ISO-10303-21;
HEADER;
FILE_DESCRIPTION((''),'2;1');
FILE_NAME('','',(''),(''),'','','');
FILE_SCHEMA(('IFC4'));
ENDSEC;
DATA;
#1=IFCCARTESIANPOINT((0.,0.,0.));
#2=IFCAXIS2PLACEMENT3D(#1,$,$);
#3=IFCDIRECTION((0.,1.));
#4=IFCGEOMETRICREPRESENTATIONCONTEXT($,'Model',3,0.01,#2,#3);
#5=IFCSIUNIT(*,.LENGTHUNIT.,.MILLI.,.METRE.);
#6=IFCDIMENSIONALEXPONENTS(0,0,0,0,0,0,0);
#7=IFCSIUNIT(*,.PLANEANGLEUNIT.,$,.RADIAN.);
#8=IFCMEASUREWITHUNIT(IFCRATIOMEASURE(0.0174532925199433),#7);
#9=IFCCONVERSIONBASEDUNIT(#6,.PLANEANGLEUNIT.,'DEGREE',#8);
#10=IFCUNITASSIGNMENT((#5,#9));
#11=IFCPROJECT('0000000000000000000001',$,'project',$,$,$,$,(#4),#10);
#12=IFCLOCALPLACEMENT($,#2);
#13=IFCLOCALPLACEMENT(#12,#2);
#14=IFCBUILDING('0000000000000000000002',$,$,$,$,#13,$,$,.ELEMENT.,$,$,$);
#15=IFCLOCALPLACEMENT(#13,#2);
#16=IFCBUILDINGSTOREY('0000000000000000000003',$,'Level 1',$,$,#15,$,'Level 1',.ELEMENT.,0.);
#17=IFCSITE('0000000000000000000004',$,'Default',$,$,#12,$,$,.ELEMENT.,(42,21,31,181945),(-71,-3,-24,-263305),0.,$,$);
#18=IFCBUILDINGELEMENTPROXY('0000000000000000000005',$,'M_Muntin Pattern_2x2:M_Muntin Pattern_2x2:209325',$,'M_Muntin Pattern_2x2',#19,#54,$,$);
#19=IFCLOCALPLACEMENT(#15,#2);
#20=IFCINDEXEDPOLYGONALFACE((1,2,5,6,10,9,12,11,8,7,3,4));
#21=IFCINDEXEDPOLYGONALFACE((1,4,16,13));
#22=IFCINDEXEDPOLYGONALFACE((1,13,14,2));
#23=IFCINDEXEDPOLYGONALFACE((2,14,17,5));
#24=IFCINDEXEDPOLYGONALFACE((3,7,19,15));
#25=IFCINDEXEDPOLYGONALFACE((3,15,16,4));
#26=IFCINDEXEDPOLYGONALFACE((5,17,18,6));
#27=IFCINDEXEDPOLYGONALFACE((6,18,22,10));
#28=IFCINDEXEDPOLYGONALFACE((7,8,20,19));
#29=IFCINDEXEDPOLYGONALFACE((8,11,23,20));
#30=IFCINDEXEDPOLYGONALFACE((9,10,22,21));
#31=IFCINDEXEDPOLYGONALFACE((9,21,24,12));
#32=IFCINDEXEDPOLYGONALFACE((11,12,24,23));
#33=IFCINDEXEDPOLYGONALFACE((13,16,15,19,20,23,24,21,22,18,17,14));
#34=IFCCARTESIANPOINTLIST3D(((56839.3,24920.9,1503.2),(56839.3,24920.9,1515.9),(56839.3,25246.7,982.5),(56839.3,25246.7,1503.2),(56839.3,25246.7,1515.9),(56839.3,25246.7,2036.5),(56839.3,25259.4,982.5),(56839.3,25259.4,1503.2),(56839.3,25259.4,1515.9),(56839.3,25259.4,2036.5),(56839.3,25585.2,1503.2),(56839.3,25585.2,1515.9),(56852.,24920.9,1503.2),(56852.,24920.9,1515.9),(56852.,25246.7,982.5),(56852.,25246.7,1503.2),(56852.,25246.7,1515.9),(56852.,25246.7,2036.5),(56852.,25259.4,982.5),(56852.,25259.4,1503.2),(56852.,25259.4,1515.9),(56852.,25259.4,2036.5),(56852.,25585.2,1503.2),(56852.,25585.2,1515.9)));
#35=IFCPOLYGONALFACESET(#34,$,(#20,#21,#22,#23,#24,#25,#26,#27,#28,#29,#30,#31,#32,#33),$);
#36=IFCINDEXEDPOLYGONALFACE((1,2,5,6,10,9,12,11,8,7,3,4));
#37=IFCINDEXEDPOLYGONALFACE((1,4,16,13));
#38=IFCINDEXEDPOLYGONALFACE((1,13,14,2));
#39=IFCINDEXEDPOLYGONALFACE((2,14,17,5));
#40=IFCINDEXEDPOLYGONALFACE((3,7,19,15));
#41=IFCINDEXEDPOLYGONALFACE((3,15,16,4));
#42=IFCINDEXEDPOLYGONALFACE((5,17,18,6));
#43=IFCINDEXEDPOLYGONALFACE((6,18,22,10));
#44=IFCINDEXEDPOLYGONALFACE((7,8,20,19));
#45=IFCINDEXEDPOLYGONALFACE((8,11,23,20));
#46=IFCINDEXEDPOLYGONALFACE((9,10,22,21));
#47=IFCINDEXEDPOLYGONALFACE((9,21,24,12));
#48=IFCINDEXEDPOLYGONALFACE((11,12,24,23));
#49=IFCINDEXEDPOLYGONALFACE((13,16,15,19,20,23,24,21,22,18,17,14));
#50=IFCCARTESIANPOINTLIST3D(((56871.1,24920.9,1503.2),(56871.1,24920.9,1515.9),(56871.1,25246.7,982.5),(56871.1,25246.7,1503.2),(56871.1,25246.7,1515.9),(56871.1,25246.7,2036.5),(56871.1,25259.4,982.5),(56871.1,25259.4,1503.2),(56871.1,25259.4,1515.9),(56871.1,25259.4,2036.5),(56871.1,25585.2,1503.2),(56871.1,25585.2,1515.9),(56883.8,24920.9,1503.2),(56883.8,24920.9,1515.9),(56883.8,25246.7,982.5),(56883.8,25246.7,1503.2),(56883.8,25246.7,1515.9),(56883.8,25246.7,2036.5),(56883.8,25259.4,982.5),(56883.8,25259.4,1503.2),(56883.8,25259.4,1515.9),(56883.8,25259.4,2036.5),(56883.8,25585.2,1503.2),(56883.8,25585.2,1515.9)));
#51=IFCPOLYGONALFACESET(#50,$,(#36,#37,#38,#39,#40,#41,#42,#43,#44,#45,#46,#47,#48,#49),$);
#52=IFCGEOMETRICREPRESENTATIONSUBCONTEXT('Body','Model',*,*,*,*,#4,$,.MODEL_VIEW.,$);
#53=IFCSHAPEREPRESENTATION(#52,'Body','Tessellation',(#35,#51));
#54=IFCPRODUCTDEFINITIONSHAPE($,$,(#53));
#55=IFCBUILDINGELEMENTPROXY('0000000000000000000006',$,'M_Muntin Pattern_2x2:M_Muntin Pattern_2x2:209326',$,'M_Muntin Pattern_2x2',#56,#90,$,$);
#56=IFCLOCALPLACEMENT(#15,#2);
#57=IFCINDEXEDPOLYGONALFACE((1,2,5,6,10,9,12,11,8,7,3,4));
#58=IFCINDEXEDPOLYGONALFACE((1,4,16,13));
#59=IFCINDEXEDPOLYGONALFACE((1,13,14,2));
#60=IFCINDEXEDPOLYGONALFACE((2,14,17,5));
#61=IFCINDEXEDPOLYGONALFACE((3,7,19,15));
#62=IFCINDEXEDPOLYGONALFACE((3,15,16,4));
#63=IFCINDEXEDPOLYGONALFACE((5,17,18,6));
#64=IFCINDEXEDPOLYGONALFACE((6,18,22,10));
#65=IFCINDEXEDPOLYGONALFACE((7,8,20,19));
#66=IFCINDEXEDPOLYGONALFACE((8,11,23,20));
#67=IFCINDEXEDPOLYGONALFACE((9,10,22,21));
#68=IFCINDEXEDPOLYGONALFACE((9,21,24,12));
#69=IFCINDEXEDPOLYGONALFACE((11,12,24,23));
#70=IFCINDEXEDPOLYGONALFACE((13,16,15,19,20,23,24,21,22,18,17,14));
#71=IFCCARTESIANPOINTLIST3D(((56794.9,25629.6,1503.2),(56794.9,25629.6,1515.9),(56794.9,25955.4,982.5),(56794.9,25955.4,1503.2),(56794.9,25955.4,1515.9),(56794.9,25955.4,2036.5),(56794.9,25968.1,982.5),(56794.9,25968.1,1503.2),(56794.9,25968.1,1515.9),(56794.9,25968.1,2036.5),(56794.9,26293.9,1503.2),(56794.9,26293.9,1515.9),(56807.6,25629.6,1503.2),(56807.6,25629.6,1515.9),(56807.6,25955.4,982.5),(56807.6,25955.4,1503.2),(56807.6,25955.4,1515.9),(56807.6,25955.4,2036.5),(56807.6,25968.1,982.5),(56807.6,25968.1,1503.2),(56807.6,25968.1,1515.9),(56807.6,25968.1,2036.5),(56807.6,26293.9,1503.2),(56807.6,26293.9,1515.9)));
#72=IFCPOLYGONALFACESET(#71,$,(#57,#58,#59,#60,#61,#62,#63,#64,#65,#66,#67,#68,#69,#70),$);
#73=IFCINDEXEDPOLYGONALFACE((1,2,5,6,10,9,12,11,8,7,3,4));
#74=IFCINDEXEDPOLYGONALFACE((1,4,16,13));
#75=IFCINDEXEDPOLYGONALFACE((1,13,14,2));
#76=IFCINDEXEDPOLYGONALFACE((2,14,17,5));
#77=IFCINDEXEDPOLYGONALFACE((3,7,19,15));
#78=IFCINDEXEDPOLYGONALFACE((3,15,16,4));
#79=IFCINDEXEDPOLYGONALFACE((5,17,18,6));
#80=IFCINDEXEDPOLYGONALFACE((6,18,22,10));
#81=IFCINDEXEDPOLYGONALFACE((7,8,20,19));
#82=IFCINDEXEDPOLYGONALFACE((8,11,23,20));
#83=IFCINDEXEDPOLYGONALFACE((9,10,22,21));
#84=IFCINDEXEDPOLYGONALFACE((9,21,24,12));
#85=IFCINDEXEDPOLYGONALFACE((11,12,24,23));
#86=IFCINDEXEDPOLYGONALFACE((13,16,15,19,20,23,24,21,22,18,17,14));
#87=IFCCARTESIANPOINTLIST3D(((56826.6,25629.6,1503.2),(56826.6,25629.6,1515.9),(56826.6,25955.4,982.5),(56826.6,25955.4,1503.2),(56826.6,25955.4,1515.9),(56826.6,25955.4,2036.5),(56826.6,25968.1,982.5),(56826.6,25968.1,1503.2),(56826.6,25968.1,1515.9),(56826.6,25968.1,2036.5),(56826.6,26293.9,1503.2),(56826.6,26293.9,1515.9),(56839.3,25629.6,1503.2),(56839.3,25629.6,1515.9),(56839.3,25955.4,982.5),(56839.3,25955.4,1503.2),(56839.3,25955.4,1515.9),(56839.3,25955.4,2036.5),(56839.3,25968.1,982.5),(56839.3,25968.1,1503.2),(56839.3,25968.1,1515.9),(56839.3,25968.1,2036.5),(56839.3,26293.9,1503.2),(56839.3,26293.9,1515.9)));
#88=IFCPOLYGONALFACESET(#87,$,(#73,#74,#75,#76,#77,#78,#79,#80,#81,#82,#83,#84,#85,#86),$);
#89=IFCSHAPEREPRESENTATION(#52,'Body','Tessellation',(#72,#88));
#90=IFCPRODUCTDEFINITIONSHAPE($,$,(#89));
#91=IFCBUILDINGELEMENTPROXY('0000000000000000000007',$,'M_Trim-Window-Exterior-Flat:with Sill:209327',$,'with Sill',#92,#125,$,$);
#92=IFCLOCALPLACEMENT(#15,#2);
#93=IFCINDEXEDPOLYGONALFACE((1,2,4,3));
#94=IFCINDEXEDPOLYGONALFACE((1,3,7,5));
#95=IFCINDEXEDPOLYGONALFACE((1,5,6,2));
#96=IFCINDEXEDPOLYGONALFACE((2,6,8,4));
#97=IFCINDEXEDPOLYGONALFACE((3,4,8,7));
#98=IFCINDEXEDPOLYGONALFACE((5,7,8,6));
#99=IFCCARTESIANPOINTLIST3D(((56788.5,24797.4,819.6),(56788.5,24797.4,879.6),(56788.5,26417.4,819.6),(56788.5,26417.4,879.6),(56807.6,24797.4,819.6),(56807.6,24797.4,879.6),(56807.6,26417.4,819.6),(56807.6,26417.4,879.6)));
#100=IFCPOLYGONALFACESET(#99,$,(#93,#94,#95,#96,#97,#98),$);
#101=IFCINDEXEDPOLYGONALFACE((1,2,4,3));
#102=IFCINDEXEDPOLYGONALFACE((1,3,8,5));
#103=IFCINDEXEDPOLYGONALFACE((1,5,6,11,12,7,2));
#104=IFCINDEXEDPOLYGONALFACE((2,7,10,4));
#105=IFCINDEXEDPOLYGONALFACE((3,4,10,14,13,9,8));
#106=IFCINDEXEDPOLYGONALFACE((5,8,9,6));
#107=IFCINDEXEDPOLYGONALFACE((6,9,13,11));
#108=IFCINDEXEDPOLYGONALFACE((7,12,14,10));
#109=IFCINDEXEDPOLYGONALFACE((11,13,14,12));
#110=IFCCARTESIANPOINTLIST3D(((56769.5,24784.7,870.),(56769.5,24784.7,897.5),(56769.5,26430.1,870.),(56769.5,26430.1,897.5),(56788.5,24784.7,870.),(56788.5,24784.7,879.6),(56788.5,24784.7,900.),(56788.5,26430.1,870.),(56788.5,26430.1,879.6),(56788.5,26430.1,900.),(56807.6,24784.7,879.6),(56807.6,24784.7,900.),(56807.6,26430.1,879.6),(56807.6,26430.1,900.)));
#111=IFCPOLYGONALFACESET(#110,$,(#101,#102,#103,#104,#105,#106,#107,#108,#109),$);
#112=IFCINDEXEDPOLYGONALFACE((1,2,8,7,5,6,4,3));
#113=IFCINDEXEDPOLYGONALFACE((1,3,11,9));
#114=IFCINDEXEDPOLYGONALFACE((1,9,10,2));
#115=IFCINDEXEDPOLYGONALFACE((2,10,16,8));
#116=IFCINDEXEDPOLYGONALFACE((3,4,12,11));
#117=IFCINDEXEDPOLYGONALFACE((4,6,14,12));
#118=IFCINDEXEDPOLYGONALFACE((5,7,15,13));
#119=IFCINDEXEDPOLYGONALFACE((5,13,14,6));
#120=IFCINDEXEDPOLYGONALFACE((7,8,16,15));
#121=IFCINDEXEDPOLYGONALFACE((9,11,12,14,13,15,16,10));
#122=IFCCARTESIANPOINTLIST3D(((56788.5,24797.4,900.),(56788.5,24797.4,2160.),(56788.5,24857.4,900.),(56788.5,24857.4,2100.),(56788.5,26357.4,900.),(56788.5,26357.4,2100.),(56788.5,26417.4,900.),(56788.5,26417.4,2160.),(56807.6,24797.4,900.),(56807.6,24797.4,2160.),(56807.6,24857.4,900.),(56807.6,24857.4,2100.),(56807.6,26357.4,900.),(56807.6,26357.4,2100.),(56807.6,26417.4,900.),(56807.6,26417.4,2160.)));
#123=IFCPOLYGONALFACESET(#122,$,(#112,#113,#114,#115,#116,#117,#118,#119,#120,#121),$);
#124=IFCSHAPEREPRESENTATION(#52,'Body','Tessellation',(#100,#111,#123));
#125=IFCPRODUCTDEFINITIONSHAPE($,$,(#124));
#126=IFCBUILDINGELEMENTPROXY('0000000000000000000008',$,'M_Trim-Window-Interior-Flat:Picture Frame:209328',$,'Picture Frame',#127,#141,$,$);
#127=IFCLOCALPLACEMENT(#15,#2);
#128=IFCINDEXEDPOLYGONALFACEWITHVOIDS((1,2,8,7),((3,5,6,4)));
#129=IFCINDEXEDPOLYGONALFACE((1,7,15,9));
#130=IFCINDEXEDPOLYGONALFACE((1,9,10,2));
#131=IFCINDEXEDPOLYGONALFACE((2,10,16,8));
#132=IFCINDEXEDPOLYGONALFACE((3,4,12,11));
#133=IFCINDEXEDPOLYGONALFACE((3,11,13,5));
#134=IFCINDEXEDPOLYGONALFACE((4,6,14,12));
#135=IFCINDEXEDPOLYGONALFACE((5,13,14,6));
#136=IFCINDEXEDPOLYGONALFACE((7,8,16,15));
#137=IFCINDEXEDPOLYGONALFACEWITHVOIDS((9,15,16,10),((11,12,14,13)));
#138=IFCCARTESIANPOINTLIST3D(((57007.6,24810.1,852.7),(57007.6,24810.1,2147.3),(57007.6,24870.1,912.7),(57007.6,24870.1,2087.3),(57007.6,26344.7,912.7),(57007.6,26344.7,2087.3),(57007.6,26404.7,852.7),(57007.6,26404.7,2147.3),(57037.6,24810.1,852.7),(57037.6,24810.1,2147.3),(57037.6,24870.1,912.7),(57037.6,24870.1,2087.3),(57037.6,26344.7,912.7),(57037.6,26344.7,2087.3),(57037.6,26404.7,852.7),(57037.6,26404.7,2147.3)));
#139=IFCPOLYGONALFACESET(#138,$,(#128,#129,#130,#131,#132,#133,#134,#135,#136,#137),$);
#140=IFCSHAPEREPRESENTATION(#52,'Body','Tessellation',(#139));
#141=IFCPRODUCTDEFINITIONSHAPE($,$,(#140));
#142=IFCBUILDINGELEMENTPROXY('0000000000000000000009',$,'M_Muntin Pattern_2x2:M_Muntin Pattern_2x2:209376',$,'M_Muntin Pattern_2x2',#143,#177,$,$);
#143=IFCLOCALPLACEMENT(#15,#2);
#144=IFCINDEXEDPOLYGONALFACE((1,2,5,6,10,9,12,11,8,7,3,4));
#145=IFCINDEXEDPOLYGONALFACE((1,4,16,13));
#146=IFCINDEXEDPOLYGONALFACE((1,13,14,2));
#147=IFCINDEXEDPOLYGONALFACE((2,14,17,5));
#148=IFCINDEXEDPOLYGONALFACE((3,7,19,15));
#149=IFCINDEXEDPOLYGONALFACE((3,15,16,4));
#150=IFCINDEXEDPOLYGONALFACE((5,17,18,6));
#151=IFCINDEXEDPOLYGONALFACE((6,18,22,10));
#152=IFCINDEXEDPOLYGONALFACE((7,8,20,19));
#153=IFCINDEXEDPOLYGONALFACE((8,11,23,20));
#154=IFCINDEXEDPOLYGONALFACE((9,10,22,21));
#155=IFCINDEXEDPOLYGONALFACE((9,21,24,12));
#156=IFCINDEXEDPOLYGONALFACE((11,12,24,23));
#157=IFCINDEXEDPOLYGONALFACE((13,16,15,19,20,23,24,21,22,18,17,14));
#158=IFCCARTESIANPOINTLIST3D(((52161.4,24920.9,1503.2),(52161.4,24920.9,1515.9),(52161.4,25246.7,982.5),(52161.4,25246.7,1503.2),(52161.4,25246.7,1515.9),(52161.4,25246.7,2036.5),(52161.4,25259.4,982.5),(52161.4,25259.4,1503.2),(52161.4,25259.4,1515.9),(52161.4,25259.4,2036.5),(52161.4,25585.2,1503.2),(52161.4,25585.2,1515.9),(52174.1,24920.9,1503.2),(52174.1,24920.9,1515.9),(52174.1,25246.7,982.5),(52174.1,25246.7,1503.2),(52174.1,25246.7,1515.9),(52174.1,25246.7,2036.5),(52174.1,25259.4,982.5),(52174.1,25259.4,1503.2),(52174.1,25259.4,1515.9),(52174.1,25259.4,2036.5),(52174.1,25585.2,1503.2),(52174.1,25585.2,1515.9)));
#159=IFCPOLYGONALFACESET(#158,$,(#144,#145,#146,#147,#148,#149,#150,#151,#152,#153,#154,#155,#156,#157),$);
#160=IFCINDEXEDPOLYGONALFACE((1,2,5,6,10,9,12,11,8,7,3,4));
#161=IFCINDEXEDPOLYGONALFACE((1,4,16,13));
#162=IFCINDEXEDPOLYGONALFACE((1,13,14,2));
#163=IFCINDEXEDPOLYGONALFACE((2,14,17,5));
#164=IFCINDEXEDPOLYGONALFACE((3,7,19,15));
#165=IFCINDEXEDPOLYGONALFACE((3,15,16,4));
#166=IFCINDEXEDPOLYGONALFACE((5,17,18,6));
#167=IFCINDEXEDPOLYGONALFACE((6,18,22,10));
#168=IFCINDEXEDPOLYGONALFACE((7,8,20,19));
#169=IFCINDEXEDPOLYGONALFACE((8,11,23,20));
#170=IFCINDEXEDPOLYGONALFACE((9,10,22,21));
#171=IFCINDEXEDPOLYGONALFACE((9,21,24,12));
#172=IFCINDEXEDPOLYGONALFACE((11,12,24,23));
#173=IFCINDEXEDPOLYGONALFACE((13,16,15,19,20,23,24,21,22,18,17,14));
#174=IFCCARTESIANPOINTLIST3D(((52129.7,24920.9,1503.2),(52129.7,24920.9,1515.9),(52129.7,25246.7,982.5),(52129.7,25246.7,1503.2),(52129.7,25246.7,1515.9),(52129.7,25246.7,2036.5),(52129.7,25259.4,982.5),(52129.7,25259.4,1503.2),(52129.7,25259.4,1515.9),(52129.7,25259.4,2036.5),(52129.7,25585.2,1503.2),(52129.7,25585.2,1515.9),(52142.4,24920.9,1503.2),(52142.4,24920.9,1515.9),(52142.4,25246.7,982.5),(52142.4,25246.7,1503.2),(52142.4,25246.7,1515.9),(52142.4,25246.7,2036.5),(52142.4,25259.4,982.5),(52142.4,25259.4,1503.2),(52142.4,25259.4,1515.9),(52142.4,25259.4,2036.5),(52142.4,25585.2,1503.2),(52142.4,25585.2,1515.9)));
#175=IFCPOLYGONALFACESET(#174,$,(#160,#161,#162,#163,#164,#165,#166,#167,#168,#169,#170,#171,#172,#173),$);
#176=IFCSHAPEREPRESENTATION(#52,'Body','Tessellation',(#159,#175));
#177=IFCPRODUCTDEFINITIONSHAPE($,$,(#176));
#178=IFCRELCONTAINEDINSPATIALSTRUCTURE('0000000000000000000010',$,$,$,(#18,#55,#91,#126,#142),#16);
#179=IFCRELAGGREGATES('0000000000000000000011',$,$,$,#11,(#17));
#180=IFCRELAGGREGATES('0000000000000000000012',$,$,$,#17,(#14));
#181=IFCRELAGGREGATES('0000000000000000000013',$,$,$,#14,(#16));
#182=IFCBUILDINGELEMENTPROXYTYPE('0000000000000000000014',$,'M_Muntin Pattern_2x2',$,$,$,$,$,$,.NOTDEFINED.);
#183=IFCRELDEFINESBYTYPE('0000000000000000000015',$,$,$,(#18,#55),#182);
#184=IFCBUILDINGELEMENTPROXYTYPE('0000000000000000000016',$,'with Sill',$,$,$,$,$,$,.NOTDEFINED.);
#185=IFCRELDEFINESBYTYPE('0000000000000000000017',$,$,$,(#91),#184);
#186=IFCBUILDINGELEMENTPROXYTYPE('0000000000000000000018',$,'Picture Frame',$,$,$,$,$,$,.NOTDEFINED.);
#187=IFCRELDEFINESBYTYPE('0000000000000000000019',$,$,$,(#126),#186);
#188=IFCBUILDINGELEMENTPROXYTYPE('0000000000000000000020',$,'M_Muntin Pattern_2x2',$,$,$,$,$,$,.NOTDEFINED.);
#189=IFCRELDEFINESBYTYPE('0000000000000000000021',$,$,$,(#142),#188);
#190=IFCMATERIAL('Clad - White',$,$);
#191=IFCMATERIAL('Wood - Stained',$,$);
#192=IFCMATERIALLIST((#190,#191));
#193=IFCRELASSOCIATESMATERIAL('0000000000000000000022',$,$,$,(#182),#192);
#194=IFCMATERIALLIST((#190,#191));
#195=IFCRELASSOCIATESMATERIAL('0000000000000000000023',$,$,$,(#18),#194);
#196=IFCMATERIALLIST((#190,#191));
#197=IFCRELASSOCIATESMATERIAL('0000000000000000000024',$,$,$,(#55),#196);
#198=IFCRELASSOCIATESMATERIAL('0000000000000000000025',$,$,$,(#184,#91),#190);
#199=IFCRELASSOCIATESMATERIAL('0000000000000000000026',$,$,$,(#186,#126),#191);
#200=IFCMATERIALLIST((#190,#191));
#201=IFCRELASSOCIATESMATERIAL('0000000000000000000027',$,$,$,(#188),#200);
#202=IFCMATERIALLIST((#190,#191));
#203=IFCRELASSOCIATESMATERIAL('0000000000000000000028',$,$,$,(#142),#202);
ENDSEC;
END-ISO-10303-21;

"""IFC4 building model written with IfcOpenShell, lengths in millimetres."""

from ifc_helpers import new_model, entity, si_unit, converted_unit, direction, frame, frame_2d, origin, place, context, subcontext, project, spatial, polyline, rectangle, outline, extrude, source, transform, mapped, material, material_list, type_object, type_shapes, element, save


model = new_model("IFC4")

# Units and contexts
model_context = context("Model", 3, precision=0.01, world=origin(), true_north=direction((0.0, 1.0)))
body_context = subcontext(model_context, "Body", "Model", "MODEL_VIEW")
ifc_project = project(units=[si_unit("LENGTHUNIT", "METRE", prefix="MILLI"), converted_unit("PLANEANGLEUNIT", "DEGREE", entity("IfcRatioMeasure", 0.0174532925199433), si_unit("PLANEANGLEUNIT", "RADIAN"), dimensions=[0, 0, 0, 0, 0, 0, 0])], contexts=[model_context])

# Site, building, storey
site_placement = place(None, origin())
site = spatial("IfcSite", under=ifc_project, at=site_placement, Name="Default", CompositionType="ELEMENT", RefLatitude=(42, 21, 31, 181945), RefLongitude=(-71, -3, -24, -263305), RefElevation=0.0)
building_placement = place(site_placement, origin())
building = spatial("IfcBuilding", under=site, at=building_placement, CompositionType="ELEMENT")
storey_placement = place(building_placement, origin())
storey = spatial("IfcBuildingStorey", under=building, at=storey_placement, Name="Level 1", LongName="Level 1", CompositionType="ELEMENT", Elevation=0.0)

# Building element proxies
ifc_material_1 = material(Name="Clad - White")
ifc_material_2 = material(Name="Wood - Stained")
ifc_material_list_1 = material_list([ifc_material_1, ifc_material_2])
ifc_material_list_2 = material_list([ifc_material_1, ifc_material_2])
building_element_proxy_type_1 = type_object("IfcBuildingElementProxyType", Name="M_Muntin Pattern_2x2", PredefinedType="NOTDEFINED", material=ifc_material_list_2)
shared_shape_1 = source(origin(), body_context, "Body", "SweptSolid", [
    extrude(outline(polyline([(6.4, -6.4), (527.0, -6.4), (527.0, 6.3), (6.4, 6.3), (6.4, 332.1), (-6.3, 332.1), (-6.3, 6.3), (-527.0, 6.3), (-527.0, -6.4), (-6.3, -6.4), (-6.3, -332.1), (6.4, -332.1), (6.4, -6.4)])), frame((0.0, -22.2, 527.0), z_axis=(0.0, 1.0, 0.0), x_axis=(0.0, 0.0, 1.0)), (0.0, 0.0, 1.0), 12.7),
    extrude(outline(polyline([(6.4, -6.4), (527.0, -6.4), (527.0, 6.3), (6.4, 6.3), (6.4, 332.1), (-6.3, 332.1), (-6.3, 6.3), (-527.0, 6.3), (-527.0, -6.4), (-6.3, -6.4), (-6.3, -332.1), (6.4, -332.1), (6.4, -6.4)])), frame((0.0, 9.5, 527.0), z_axis=(0.0, 1.0, 0.0), x_axis=(0.0, 0.0, 1.0)), (0.0, 0.0, 1.0), 12.7),
])
type_shapes(building_element_proxy_type_1, [shared_shape_1])
proxy_1_placement = place(storey_placement, frame((56861.6, 25253.0, 982.5), z_axis=(0.0, 0.0, 1.0), x_axis=(0.0, -1.0, 0.0)))
element("IfcBuildingElementProxy", 1, at=proxy_1_placement, inside=storey, type_object=building_element_proxy_type_1, material=ifc_material_list_1, Name="M_Muntin Pattern_2x2:M_Muntin Pattern_2x2:209325", ObjectType="M_Muntin Pattern_2x2", context=body_context, shape_type="MappedRepresentation", body=[
    mapped(shared_shape_1, transform((0.0, 0.0, 0.0), scale=1.0)),
])
ifc_material_list_3 = material_list([ifc_material_1, ifc_material_2])
proxy_2_placement = place(storey_placement, frame((56817.1, 25961.7, 982.5), z_axis=(0.0, 0.0, 1.0), x_axis=(0.0, -1.0, 0.0)))
element("IfcBuildingElementProxy", 2, at=proxy_2_placement, inside=storey, type_object=building_element_proxy_type_1, material=ifc_material_list_3, Name="M_Muntin Pattern_2x2:M_Muntin Pattern_2x2:209326", ObjectType="M_Muntin Pattern_2x2", context=body_context, shape_type="MappedRepresentation", body=[
    mapped(shared_shape_1, transform((0.0, 0.0, 0.0), scale=1.0)),
])
building_element_proxy_type_2 = type_object("IfcBuildingElementProxyType", Name="with Sill", PredefinedType="NOTDEFINED", material=ifc_material_1)
shared_shape_2 = source(origin(), body_context, "Body", "SweptSolid", [
    extrude(rectangle(XDim=60.0, YDim=1620.0, at=frame_2d((0.0, 0.0), x_axis=(1.0, 0.0))), frame((0.0, 1250.4, 0.0), z_axis=(0.0, 0.0, 1.0), x_axis=(0.0, 1.0, 0.0)), (0.0, 0.0, 1.0), 19.1),
    extrude(outline(polyline([(-15.2, -19.0), (12.3, -19.0), (14.8, 0.0), (14.8, 19.0), (-5.7, 19.0), (-5.7, 0.0), (-15.2, 0.0), (-15.2, -19.0)])), frame((-822.7, 1214.8, 19.0), z_axis=(1.0, 0.0, 0.0), x_axis=(0.0, -1.0, 0.0)), (0.0, 0.0, 1.0), 1645.4),
    extrude(outline(polyline([(-810.0, -645.0), (810.0, -645.0), (810.0, 615.0), (750.0, 615.0), (750.0, -585.0), (-750.0, -585.0), (-750.0, 615.0), (-810.0, 615.0), (-810.0, -645.0)])), frame((0.0, 585.0, 0.0)), (0.0, 0.0, 1.0), 19.1),
])
type_shapes(building_element_proxy_type_2, [shared_shape_2])
proxy_3_placement = place(storey_placement, frame((56807.6, 25607.4, 2100.0), z_axis=(-1.0, 0.0, 0.0), x_axis=(0.0, 1.0, 0.0)))
element("IfcBuildingElementProxy", 3, at=proxy_3_placement, inside=storey, type_object=building_element_proxy_type_2, material=ifc_material_1, Name="M_Trim-Window-Exterior-Flat:with Sill:209327", ObjectType="with Sill", context=body_context, shape_type="MappedRepresentation", body=[
    mapped(shared_shape_2, transform((0.0, 0.0, 0.0), scale=1.0)),
])
building_element_proxy_type_3 = type_object("IfcBuildingElementProxyType", Name="Picture Frame", PredefinedType="NOTDEFINED", material=ifc_material_2)
shared_shape_3 = source(origin(), body_context, "Body", "SweptSolid", [
    extrude(outline(polyline([(-647.3, -797.3), (647.3, -797.3), (647.3, 797.3), (-647.3, 797.3), (-647.3, -797.3)]), holes=[polyline([(-587.3, -737.3), (-587.3, 737.3), (587.3, 737.3), (587.3, -737.3), (-587.3, -737.3)])]), frame((0.0, 600.0, 0.0), z_axis=(0.0, 0.0, 1.0), x_axis=(0.0, 1.0, 0.0)), (0.0, 0.0, 1.0), 30.0),
])
type_shapes(building_element_proxy_type_3, [shared_shape_3])
proxy_4_placement = place(storey_placement, frame((57007.6, 25607.4, 2100.0), z_axis=(1.0, 0.0, 0.0), x_axis=(0.0, -1.0, 0.0)))
element("IfcBuildingElementProxy", 4, at=proxy_4_placement, inside=storey, type_object=building_element_proxy_type_3, material=ifc_material_2, Name="M_Trim-Window-Interior-Flat:Picture Frame:209328", ObjectType="Picture Frame", context=body_context, shape_type="MappedRepresentation", body=[
    mapped(shared_shape_3, transform((0.0, 0.0, 0.0), scale=1.0)),
])
ifc_material_list_4 = material_list([ifc_material_1, ifc_material_2])
ifc_material_list_5 = material_list([ifc_material_1, ifc_material_2])
building_element_proxy_type_4 = type_object("IfcBuildingElementProxyType", Name="M_Muntin Pattern_2x2", PredefinedType="NOTDEFINED", material=ifc_material_list_5)
shared_shape_4 = source(origin(), body_context, "Body", "SweptSolid", [
    extrude(outline(polyline([(6.4, -6.4), (527.0, -6.4), (527.0, 6.3), (6.4, 6.3), (6.4, 332.1), (-6.3, 332.1), (-6.3, 6.3), (-527.0, 6.3), (-527.0, -6.4), (-6.3, -6.4), (-6.3, -332.1), (6.4, -332.1), (6.4, -6.4)])), frame((0.0, 9.5, 527.0), z_axis=(0.0, 1.0, 0.0), x_axis=(0.0, 0.0, 1.0)), (0.0, 0.0, 1.0), 12.7),
    extrude(outline(polyline([(6.4, -6.4), (527.0, -6.4), (527.0, 6.3), (6.4, 6.3), (6.4, 332.1), (-6.3, 332.1), (-6.3, 6.3), (-527.0, 6.3), (-527.0, -6.4), (-6.3, -6.4), (-6.3, -332.1), (6.4, -332.1), (6.4, -6.4)])), frame((0.0, -22.2, 527.0), z_axis=(0.0, 1.0, 0.0), x_axis=(0.0, 0.0, 1.0)), (0.0, 0.0, 1.0), 12.7),
])
type_shapes(building_element_proxy_type_4, [shared_shape_4])
proxy_5_placement = place(storey_placement, frame((52151.9, 25253.0, 982.5), z_axis=(0.0, 0.0, 1.0), x_axis=(0.0, -1.0, 0.0)))
element("IfcBuildingElementProxy", 5, at=proxy_5_placement, inside=storey, type_object=building_element_proxy_type_4, material=ifc_material_list_4, Name="M_Muntin Pattern_2x2:M_Muntin Pattern_2x2:209376", ObjectType="M_Muntin Pattern_2x2", context=body_context, shape_type="MappedRepresentation", body=[
    mapped(shared_shape_4, transform((0.0, 0.0, 0.0), scale=1.0)),
])

save(model, "model.ifc")
